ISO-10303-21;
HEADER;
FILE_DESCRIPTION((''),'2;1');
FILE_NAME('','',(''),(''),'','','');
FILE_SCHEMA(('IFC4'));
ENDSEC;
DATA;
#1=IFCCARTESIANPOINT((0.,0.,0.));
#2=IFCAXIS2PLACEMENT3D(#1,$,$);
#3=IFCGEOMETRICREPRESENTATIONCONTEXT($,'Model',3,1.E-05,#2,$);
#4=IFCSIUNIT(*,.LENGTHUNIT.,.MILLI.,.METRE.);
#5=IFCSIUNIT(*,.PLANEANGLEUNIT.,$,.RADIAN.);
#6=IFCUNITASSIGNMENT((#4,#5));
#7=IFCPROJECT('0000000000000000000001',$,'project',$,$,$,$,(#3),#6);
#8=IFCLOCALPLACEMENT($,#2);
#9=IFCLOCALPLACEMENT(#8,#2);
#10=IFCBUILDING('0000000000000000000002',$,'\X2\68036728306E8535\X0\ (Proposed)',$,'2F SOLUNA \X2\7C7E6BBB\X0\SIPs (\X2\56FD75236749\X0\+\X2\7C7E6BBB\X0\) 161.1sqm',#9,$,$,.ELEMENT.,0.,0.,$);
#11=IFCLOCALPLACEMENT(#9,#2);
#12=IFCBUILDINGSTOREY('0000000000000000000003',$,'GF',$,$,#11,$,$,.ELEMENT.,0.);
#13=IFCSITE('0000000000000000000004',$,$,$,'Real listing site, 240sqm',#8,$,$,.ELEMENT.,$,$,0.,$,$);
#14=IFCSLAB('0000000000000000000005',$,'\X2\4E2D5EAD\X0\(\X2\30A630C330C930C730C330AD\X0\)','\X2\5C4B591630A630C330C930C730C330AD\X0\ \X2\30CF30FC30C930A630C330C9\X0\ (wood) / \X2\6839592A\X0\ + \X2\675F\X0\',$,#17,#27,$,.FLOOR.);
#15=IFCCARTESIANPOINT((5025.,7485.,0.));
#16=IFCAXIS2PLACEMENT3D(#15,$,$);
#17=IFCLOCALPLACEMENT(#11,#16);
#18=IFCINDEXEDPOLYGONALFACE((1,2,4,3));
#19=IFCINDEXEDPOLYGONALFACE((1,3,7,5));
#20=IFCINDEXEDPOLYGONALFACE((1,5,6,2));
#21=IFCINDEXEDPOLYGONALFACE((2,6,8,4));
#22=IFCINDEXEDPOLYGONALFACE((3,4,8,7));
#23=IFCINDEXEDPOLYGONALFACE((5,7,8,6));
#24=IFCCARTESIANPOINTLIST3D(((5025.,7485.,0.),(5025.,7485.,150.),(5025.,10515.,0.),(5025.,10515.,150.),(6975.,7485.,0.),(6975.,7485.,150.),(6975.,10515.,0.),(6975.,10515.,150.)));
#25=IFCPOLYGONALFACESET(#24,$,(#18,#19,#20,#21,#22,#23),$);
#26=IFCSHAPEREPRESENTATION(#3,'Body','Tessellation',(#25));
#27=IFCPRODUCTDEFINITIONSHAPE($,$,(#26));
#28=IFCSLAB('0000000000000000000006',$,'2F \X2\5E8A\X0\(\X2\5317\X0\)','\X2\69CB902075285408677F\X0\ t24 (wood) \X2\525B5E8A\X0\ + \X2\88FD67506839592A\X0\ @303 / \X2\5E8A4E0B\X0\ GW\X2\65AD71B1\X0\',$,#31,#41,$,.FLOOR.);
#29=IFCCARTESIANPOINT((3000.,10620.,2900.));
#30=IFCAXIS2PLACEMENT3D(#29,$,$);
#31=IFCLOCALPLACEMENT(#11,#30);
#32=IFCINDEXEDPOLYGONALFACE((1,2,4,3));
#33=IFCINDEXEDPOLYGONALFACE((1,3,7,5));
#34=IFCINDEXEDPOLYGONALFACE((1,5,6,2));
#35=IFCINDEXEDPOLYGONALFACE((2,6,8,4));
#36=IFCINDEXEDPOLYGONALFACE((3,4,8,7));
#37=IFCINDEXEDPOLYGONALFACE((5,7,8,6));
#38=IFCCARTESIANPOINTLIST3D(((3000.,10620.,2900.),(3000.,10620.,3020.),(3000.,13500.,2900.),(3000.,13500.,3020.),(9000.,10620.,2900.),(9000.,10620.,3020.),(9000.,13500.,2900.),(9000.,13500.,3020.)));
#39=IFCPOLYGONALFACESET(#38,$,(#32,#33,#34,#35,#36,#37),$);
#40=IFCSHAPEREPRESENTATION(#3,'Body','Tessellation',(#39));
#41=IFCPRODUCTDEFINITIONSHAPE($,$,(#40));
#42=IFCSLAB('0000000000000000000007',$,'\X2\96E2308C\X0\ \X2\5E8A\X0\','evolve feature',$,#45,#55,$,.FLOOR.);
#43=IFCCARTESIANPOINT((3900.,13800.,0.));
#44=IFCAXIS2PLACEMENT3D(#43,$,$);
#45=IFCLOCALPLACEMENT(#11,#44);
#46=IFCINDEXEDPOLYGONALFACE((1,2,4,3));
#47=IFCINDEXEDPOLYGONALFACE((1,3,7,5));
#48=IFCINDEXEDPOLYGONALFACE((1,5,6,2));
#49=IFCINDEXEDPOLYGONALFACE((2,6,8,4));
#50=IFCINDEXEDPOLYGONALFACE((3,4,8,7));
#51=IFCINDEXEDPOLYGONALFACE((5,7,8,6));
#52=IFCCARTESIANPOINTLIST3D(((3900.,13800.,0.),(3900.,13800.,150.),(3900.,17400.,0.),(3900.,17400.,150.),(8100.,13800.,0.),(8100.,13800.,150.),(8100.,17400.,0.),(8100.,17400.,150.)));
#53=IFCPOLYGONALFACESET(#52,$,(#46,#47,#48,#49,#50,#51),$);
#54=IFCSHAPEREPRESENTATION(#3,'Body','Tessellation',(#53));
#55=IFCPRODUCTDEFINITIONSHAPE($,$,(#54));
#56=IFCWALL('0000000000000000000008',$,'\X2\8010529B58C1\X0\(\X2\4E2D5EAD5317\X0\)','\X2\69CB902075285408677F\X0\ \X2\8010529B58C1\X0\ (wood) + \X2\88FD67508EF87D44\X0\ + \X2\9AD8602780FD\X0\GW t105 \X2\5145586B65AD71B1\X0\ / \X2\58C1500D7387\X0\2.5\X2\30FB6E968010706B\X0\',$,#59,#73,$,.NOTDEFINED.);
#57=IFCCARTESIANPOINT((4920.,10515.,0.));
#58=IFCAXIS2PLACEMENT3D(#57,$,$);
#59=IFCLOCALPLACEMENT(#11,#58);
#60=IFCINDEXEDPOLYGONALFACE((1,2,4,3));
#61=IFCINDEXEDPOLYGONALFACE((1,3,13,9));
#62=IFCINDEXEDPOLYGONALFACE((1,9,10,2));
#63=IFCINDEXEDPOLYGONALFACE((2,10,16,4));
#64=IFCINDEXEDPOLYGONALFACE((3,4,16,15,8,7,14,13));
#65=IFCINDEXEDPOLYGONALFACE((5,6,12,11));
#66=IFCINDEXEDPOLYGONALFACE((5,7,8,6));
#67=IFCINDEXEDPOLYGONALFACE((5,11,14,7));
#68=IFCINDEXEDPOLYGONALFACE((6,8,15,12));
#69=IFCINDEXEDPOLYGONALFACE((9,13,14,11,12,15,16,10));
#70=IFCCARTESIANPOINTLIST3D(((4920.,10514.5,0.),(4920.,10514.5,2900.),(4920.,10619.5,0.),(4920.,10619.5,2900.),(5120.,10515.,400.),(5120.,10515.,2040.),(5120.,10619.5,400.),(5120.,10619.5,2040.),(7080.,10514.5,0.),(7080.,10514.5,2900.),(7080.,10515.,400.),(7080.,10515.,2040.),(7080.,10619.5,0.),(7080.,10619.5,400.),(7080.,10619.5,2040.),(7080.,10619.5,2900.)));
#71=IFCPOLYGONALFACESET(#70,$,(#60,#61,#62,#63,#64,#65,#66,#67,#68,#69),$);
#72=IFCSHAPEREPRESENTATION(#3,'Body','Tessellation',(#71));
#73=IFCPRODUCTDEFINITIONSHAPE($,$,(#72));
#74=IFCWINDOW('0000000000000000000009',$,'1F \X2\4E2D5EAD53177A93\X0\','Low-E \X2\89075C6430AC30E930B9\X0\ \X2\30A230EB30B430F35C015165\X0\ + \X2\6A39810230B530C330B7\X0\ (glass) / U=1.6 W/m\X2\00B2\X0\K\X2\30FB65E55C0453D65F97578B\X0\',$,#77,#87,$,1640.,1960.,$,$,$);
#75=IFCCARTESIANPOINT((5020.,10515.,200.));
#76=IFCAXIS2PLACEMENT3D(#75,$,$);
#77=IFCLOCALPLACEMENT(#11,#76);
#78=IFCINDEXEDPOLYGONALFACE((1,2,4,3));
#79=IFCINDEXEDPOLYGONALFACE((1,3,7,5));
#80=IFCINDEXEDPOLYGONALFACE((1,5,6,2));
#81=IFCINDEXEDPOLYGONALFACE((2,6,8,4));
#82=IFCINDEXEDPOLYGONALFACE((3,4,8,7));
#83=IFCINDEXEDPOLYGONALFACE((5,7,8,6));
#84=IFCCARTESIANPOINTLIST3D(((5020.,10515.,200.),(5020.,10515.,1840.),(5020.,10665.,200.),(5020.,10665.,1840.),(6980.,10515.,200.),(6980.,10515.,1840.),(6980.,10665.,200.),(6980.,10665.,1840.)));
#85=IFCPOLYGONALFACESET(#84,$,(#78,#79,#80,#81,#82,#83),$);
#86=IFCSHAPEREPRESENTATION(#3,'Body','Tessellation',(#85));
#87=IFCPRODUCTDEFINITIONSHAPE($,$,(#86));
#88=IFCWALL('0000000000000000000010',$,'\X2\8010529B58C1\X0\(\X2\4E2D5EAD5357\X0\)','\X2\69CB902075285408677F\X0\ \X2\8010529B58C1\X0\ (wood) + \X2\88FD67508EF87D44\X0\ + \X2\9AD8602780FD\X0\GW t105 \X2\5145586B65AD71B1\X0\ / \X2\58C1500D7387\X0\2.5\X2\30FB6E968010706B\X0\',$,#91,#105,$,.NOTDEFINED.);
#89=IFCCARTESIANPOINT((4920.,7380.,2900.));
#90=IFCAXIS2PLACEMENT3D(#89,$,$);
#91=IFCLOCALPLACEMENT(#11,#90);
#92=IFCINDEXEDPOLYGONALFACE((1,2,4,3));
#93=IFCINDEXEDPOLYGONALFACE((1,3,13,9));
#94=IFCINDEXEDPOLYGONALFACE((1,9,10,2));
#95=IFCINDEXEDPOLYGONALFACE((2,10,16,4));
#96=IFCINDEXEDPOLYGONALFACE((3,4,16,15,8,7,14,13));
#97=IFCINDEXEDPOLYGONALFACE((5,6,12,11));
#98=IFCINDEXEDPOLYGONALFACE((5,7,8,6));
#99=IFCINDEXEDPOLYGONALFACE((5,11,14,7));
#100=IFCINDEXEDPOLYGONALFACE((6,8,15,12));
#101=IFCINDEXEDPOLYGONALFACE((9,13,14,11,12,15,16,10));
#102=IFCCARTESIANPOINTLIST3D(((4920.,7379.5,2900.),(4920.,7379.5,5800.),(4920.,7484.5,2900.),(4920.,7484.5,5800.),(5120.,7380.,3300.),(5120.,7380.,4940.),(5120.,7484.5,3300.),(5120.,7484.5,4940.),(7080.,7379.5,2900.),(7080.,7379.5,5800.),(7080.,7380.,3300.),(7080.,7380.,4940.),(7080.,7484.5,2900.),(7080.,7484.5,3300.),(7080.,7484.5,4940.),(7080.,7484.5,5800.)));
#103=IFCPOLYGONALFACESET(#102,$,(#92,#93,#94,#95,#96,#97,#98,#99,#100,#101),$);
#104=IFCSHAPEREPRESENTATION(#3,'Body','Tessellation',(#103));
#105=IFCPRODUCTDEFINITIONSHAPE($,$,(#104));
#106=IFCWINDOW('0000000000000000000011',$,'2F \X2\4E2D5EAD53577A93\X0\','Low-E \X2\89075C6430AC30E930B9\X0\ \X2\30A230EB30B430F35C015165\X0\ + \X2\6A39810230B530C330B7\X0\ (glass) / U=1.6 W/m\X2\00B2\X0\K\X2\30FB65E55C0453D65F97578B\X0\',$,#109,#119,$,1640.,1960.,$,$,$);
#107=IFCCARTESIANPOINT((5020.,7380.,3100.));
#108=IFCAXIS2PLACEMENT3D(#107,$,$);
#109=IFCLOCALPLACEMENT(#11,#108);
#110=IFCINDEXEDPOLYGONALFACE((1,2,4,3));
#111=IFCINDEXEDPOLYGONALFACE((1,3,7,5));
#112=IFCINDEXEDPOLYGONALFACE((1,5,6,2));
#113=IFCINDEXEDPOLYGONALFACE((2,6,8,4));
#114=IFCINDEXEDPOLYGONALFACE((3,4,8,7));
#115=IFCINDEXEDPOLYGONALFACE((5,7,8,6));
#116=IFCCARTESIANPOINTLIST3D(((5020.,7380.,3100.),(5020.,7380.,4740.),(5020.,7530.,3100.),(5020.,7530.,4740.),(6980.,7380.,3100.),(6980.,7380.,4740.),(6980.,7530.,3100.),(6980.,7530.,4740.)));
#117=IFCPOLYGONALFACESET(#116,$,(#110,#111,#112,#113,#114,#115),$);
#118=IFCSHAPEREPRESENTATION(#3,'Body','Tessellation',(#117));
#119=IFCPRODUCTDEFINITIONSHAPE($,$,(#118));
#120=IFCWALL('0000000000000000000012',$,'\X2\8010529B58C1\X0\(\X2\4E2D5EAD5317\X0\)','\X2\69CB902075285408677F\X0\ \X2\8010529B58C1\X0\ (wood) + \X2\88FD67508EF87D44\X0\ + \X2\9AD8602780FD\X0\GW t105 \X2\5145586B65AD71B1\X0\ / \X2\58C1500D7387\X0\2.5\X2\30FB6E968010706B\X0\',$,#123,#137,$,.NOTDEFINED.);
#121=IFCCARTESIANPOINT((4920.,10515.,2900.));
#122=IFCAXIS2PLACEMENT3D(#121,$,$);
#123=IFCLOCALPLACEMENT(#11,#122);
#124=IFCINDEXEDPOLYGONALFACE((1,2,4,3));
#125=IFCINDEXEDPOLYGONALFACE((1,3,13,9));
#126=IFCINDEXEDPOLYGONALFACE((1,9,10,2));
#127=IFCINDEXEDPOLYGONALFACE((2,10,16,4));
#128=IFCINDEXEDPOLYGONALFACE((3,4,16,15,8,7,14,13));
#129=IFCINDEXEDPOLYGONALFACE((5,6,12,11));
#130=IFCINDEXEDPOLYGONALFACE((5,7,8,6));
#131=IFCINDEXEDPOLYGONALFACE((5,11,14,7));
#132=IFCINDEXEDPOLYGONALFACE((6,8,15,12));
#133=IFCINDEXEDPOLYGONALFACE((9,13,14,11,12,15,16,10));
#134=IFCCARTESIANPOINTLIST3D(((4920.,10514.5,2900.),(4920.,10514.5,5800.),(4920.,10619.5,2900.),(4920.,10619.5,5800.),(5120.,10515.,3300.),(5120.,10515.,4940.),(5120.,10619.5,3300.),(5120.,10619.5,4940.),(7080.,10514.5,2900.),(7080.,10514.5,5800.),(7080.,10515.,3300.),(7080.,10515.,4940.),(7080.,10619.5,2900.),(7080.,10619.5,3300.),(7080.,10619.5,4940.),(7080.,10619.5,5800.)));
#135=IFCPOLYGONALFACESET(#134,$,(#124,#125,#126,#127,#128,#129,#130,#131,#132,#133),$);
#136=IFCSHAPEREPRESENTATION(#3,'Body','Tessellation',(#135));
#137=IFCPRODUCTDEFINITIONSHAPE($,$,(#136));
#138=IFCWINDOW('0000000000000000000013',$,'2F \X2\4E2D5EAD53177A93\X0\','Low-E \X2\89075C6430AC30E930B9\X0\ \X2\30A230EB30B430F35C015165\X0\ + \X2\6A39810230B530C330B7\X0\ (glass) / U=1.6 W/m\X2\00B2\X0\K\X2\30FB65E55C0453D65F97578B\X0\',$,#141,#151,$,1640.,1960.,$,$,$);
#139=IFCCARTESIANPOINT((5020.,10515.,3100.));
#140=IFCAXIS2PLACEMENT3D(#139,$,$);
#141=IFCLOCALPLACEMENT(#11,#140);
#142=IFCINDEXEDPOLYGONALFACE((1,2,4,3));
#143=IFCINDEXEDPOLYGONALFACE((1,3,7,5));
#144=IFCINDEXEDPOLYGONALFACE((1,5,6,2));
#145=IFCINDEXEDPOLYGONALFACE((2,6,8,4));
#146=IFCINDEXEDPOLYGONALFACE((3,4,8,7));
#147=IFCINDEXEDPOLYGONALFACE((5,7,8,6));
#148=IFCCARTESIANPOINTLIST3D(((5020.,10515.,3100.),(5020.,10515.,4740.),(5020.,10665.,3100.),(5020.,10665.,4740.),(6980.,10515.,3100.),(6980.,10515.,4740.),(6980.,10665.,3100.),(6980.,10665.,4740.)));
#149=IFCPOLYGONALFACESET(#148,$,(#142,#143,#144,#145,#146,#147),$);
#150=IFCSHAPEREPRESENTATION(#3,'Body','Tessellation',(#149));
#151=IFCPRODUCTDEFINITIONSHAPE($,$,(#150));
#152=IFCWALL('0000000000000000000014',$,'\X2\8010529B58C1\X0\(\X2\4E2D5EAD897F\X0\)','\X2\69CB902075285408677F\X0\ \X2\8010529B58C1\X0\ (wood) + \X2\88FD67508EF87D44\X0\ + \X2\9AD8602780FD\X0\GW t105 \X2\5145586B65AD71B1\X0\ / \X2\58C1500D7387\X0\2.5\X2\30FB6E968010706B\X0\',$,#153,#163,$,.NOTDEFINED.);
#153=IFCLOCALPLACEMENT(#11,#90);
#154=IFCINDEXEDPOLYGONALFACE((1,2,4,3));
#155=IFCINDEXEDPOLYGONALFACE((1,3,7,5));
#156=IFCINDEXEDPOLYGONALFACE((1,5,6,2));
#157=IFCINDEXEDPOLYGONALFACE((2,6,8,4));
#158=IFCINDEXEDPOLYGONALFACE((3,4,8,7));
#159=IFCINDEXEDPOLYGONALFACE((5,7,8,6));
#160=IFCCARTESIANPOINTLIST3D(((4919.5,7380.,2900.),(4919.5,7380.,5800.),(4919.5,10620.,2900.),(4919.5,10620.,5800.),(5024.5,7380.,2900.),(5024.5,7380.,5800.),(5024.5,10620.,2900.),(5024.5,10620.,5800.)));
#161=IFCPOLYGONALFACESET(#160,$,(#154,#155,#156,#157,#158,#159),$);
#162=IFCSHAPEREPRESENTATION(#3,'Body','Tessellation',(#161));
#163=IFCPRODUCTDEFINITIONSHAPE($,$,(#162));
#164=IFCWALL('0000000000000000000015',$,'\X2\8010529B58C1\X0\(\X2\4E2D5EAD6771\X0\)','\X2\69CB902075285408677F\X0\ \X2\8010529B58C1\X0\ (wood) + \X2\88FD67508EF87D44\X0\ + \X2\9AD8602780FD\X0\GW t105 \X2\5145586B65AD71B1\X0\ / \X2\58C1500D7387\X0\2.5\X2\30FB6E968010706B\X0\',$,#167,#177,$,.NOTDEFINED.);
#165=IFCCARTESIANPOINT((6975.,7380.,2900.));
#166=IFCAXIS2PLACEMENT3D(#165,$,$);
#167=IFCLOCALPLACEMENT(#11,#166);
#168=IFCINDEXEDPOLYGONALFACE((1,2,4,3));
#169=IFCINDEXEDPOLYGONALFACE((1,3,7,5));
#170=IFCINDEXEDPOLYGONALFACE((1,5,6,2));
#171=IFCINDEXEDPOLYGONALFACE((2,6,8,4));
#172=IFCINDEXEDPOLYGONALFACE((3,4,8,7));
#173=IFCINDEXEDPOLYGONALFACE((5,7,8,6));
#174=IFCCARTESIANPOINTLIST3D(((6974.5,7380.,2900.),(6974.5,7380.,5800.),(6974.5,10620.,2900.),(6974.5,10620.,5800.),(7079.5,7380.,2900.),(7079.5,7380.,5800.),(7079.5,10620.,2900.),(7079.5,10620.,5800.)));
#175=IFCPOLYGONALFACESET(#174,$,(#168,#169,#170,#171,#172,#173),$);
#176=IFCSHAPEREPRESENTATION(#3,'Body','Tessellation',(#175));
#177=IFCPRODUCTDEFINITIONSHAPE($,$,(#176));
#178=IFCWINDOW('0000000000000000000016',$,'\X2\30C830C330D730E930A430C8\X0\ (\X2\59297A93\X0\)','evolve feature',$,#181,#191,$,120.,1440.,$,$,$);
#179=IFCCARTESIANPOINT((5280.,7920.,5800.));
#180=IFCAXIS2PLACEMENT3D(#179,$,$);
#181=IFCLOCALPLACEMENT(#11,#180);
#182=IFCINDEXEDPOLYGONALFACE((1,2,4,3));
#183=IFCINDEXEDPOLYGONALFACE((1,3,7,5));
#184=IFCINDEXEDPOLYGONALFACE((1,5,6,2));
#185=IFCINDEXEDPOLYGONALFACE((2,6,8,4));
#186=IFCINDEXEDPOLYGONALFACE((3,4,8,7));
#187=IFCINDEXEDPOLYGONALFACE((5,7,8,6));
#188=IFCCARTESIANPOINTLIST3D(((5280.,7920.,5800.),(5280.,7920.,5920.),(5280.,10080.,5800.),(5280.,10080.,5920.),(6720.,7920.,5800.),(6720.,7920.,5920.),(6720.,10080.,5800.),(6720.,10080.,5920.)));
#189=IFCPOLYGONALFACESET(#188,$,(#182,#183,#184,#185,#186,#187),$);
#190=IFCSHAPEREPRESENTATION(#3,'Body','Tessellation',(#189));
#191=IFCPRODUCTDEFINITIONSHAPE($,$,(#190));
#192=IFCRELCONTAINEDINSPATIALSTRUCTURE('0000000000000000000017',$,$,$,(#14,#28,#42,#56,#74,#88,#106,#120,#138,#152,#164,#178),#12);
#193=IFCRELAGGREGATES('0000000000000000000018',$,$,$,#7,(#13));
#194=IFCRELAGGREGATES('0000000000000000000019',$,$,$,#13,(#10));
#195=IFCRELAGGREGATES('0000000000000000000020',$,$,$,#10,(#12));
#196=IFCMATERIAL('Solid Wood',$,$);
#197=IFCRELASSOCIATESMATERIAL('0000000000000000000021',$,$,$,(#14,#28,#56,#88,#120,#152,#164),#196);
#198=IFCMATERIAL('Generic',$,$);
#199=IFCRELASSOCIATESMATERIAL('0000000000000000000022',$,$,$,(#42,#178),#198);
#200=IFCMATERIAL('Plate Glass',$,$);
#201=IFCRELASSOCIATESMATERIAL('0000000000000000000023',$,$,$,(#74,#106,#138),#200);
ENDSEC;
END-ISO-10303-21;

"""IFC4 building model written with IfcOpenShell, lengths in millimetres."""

from ifc_helpers import new_model, si_unit, frame, frame_2d, origin, place, context, project, spatial, rectangle, extrude, material, element, fill, save


model = new_model("IFC4")

# Units and contexts
model_context = context("Model", 3, precision=1e-05, world=origin())
ifc_project = project(units=[si_unit("LENGTHUNIT", "METRE", prefix="MILLI"), si_unit("PLANEANGLEUNIT", "RADIAN")], contexts=[model_context])

# Site, building, storey
site_placement = place(None, origin())
site = spatial("IfcSite", under=ifc_project, at=site_placement, ObjectType="Real listing site, 240sqm", CompositionType="ELEMENT", RefElevation=0.0)
building_placement = place(site_placement, origin())
building = spatial("IfcBuilding", under=site, at=building_placement, Name="栃木の蔵 (Proposed)", ObjectType="2F SOLUNA 籾殻SIPs (国産杉+籾殻) 161.1sqm", CompositionType="ELEMENT", ElevationOfRefHeight=0.0, ElevationOfTerrain=0.0)
storey_placement = place(building_placement, origin())
storey = spatial("IfcBuildingStorey", under=building, at=storey_placement, Name="GF", CompositionType="ELEMENT", Elevation=0.0)

# Slabs
ifc_material_1 = material(Name="Solid Wood")
slab_1_placement = place(storey_placement, frame((5025.0, 7485.0, 0.0)))
element("IfcSlab", 1, at=slab_1_placement, inside=storey, material=ifc_material_1, Name="中庭(ウッドデッキ)", Description="屋外ウッドデッキ ハードウッド (wood) / 根太 + 束", PredefinedType="FLOOR", context=model_context, shape_type="SweptSolid", body=[
    extrude(rectangle(XDim=1950.0, YDim=3030.0, at=frame_2d((975.0, 1515.0))), frame((5025.0, 7485.0, 0.0)), (0.0, 0.0, 1.0), 150.0),
])
slab_2_placement = place(storey_placement, frame((3000.0, 10620.0, 2900.0)))
element("IfcSlab", 2, at=slab_2_placement, inside=storey, material=ifc_material_1, Name="2F 床(北)", Description="構造用合板 t24 (wood) 剛床 + 製材根太 @303 / 床下 GW断熱", PredefinedType="FLOOR", context=model_context, shape_type="SweptSolid", body=[
    extrude(rectangle(XDim=6000.0, YDim=2880.0, at=frame_2d((3000.0, 1440.0))), frame((3000.0, 10620.0, 2900.0)), (0.0, 0.0, 1.0), 120.0),
])
ifc_material_2 = material(Name="Generic")
slab_3_placement = place(storey_placement, frame((3900.0, 13800.0, 0.0)))
element("IfcSlab", 3, at=slab_3_placement, inside=storey, material=ifc_material_2, Name="離れ 床", Description="evolve feature", PredefinedType="FLOOR", context=model_context, shape_type="SweptSolid", body=[
    extrude(rectangle(XDim=4200.0, YDim=3600.0, at=frame_2d((2100.0, 1800.0))), frame((3900.0, 13800.0, 0.0)), (0.0, 0.0, 1.0), 150.0),
])

# Wall, opening, window
wall_1_placement = place(storey_placement, frame((4920.0, 10515.0, 0.0)))
wall_1 = element("IfcWall", 4, at=wall_1_placement, inside=storey, material=ifc_material_1, Name="耐力壁(中庭北)", Description="構造用合板 耐力壁 (wood) + 製材軸組 + 高性能GW t105 充填断熱 / 壁倍率2.5・準耐火", PredefinedType="NOTDEFINED", context=model_context, shape_type="SweptSolid", body=[
    extrude(rectangle(XDim=2160.0, YDim=105.0, at=frame_2d((1080.0, 52.0))), frame((4920.0, 10515.0, 0.0)), (0.0, 0.0, 1.0), 2900.0),
])
opening_1_placement = place(storey_placement, frame((5020.0, 10515.0, 200.0)))
opening_1 = element("IfcOpeningElement", 5, at=opening_1_placement, cuts=wall_1, PredefinedType="NOTDEFINED", context=model_context, shape_type="SweptSolid", body=[
    extrude(rectangle(XDim=1960.0, YDim=150.0, at=frame_2d((980.0, 75.0))), frame((5020.0, 10515.0, 200.0)), (0.0, 0.0, 1.0), 1640.0),
])
ifc_material_3 = material(Name="Plate Glass")
window_1_placement = place(storey_placement, frame((5020.0, 10515.0, 200.0)))
window_1 = element("IfcWindow", 6, at=window_1_placement, inside=storey, material=ifc_material_3, Name="1F 中庭北窓", Description="Low-E 複層ガラス アルゴン封入 + 樹脂サッシ (glass) / U=1.6 W/m²K・日射取得型", OverallHeight=1640.0, OverallWidth=1960.0, context=model_context, shape_type="SweptSolid", body=[
    extrude(rectangle(XDim=1960.0, YDim=150.0, at=frame_2d((980.0, 75.0))), frame((5020.0, 10515.0, 200.0)), (0.0, 0.0, 1.0), 1640.0),
])
fill(opening_1, window_1)

# Walls, openings, windows
wall_2_placement = place(storey_placement, frame((4920.0, 7380.0, 2900.0)))
wall_2 = element("IfcWall", 7, at=wall_2_placement, inside=storey, material=ifc_material_1, Name="耐力壁(中庭南)", Description="構造用合板 耐力壁 (wood) + 製材軸組 + 高性能GW t105 充填断熱 / 壁倍率2.5・準耐火", PredefinedType="NOTDEFINED", context=model_context, shape_type="SweptSolid", body=[
    extrude(rectangle(XDim=2160.0, YDim=105.0, at=frame_2d((1080.0, 52.0))), frame((4920.0, 7380.0, 2900.0)), (0.0, 0.0, 1.0), 2900.0),
])
opening_2_placement = place(storey_placement, frame((5020.0, 7380.0, 3100.0)))
opening_2 = element("IfcOpeningElement", 8, at=opening_2_placement, cuts=wall_2, PredefinedType="NOTDEFINED", context=model_context, shape_type="SweptSolid", body=[
    extrude(rectangle(XDim=1960.0, YDim=150.0, at=frame_2d((980.0, 75.0))), frame((5020.0, 7380.0, 3100.0)), (0.0, 0.0, 1.0), 1640.0),
])
window_2_placement = place(storey_placement, frame((5020.0, 7380.0, 3100.0)))
window_2 = element("IfcWindow", 9, at=window_2_placement, inside=storey, material=ifc_material_3, Name="2F 中庭南窓", Description="Low-E 複層ガラス アルゴン封入 + 樹脂サッシ (glass) / U=1.6 W/m²K・日射取得型", OverallHeight=1640.0, OverallWidth=1960.0, context=model_context, shape_type="SweptSolid", body=[
    extrude(rectangle(XDim=1960.0, YDim=150.0, at=frame_2d((980.0, 75.0))), frame((5020.0, 7380.0, 3100.0)), (0.0, 0.0, 1.0), 1640.0),
])
fill(opening_2, window_2)
wall_3_placement = place(storey_placement, frame((4920.0, 10515.0, 2900.0)))
wall_3 = element("IfcWall", 10, at=wall_3_placement, inside=storey, material=ifc_material_1, Name="耐力壁(中庭北)", Description="構造用合板 耐力壁 (wood) + 製材軸組 + 高性能GW t105 充填断熱 / 壁倍率2.5・準耐火", PredefinedType="NOTDEFINED", context=model_context, shape_type="SweptSolid", body=[
    extrude(rectangle(XDim=2160.0, YDim=105.0, at=frame_2d((1080.0, 52.0))), frame((4920.0, 10515.0, 2900.0)), (0.0, 0.0, 1.0), 2900.0),
])
opening_3_placement = place(storey_placement, frame((5020.0, 10515.0, 3100.0)))
opening_3 = element("IfcOpeningElement", 11, at=opening_3_placement, cuts=wall_3, PredefinedType="NOTDEFINED", context=model_context, shape_type="SweptSolid", body=[
    extrude(rectangle(XDim=1960.0, YDim=150.0, at=frame_2d((980.0, 75.0))), frame((5020.0, 10515.0, 3100.0)), (0.0, 0.0, 1.0), 1640.0),
])
window_3_placement = place(storey_placement, frame((5020.0, 10515.0, 3100.0)))
window_3 = element("IfcWindow", 12, at=window_3_placement, inside=storey, material=ifc_material_3, Name="2F 中庭北窓", Description="Low-E 複層ガラス アルゴン封入 + 樹脂サッシ (glass) / U=1.6 W/m²K・日射取得型", OverallHeight=1640.0, OverallWidth=1960.0, context=model_context, shape_type="SweptSolid", body=[
    extrude(rectangle(XDim=1960.0, YDim=150.0, at=frame_2d((980.0, 75.0))), frame((5020.0, 10515.0, 3100.0)), (0.0, 0.0, 1.0), 1640.0),
])
fill(opening_3, window_3)

# Walls
wall_4_placement = place(storey_placement, frame((4920.0, 7380.0, 2900.0)))
element("IfcWall", 13, at=wall_4_placement, inside=storey, material=ifc_material_1, Name="耐力壁(中庭西)", Description="構造用合板 耐力壁 (wood) + 製材軸組 + 高性能GW t105 充填断熱 / 壁倍率2.5・準耐火", PredefinedType="NOTDEFINED", context=model_context, shape_type="SweptSolid", body=[
    extrude(rectangle(XDim=105.0, YDim=3240.0, at=frame_2d((52.0, 1620.0))), frame((4920.0, 7380.0, 2900.0)), (0.0, 0.0, 1.0), 2900.0),
])
wall_5_placement = place(storey_placement, frame((6975.0, 7380.0, 2900.0)))
element("IfcWall", 14, at=wall_5_placement, inside=storey, material=ifc_material_1, Name="耐力壁(中庭東)", Description="構造用合板 耐力壁 (wood) + 製材軸組 + 高性能GW t105 充填断熱 / 壁倍率2.5・準耐火", PredefinedType="NOTDEFINED", context=model_context, shape_type="SweptSolid", body=[
    extrude(rectangle(XDim=105.0, YDim=3240.0, at=frame_2d((52.0, 1620.0))), frame((6975.0, 7380.0, 2900.0)), (0.0, 0.0, 1.0), 2900.0),
])

# Window
window_4_placement = place(storey_placement, frame((5280.0, 7920.0, 5800.0)))
element("IfcWindow", 15, at=window_4_placement, inside=storey, material=ifc_material_2, Name="トップライト (天窓)", Description="evolve feature", OverallHeight=120.0, OverallWidth=1440.0, context=model_context, shape_type="SweptSolid", body=[
    extrude(rectangle(XDim=1440.0, YDim=2160.0, at=frame_2d((720.0, 1080.0))), frame((5280.0, 7920.0, 5800.0)), (0.0, 0.0, 1.0), 120.0),
])

save(model, "model.ifc")
